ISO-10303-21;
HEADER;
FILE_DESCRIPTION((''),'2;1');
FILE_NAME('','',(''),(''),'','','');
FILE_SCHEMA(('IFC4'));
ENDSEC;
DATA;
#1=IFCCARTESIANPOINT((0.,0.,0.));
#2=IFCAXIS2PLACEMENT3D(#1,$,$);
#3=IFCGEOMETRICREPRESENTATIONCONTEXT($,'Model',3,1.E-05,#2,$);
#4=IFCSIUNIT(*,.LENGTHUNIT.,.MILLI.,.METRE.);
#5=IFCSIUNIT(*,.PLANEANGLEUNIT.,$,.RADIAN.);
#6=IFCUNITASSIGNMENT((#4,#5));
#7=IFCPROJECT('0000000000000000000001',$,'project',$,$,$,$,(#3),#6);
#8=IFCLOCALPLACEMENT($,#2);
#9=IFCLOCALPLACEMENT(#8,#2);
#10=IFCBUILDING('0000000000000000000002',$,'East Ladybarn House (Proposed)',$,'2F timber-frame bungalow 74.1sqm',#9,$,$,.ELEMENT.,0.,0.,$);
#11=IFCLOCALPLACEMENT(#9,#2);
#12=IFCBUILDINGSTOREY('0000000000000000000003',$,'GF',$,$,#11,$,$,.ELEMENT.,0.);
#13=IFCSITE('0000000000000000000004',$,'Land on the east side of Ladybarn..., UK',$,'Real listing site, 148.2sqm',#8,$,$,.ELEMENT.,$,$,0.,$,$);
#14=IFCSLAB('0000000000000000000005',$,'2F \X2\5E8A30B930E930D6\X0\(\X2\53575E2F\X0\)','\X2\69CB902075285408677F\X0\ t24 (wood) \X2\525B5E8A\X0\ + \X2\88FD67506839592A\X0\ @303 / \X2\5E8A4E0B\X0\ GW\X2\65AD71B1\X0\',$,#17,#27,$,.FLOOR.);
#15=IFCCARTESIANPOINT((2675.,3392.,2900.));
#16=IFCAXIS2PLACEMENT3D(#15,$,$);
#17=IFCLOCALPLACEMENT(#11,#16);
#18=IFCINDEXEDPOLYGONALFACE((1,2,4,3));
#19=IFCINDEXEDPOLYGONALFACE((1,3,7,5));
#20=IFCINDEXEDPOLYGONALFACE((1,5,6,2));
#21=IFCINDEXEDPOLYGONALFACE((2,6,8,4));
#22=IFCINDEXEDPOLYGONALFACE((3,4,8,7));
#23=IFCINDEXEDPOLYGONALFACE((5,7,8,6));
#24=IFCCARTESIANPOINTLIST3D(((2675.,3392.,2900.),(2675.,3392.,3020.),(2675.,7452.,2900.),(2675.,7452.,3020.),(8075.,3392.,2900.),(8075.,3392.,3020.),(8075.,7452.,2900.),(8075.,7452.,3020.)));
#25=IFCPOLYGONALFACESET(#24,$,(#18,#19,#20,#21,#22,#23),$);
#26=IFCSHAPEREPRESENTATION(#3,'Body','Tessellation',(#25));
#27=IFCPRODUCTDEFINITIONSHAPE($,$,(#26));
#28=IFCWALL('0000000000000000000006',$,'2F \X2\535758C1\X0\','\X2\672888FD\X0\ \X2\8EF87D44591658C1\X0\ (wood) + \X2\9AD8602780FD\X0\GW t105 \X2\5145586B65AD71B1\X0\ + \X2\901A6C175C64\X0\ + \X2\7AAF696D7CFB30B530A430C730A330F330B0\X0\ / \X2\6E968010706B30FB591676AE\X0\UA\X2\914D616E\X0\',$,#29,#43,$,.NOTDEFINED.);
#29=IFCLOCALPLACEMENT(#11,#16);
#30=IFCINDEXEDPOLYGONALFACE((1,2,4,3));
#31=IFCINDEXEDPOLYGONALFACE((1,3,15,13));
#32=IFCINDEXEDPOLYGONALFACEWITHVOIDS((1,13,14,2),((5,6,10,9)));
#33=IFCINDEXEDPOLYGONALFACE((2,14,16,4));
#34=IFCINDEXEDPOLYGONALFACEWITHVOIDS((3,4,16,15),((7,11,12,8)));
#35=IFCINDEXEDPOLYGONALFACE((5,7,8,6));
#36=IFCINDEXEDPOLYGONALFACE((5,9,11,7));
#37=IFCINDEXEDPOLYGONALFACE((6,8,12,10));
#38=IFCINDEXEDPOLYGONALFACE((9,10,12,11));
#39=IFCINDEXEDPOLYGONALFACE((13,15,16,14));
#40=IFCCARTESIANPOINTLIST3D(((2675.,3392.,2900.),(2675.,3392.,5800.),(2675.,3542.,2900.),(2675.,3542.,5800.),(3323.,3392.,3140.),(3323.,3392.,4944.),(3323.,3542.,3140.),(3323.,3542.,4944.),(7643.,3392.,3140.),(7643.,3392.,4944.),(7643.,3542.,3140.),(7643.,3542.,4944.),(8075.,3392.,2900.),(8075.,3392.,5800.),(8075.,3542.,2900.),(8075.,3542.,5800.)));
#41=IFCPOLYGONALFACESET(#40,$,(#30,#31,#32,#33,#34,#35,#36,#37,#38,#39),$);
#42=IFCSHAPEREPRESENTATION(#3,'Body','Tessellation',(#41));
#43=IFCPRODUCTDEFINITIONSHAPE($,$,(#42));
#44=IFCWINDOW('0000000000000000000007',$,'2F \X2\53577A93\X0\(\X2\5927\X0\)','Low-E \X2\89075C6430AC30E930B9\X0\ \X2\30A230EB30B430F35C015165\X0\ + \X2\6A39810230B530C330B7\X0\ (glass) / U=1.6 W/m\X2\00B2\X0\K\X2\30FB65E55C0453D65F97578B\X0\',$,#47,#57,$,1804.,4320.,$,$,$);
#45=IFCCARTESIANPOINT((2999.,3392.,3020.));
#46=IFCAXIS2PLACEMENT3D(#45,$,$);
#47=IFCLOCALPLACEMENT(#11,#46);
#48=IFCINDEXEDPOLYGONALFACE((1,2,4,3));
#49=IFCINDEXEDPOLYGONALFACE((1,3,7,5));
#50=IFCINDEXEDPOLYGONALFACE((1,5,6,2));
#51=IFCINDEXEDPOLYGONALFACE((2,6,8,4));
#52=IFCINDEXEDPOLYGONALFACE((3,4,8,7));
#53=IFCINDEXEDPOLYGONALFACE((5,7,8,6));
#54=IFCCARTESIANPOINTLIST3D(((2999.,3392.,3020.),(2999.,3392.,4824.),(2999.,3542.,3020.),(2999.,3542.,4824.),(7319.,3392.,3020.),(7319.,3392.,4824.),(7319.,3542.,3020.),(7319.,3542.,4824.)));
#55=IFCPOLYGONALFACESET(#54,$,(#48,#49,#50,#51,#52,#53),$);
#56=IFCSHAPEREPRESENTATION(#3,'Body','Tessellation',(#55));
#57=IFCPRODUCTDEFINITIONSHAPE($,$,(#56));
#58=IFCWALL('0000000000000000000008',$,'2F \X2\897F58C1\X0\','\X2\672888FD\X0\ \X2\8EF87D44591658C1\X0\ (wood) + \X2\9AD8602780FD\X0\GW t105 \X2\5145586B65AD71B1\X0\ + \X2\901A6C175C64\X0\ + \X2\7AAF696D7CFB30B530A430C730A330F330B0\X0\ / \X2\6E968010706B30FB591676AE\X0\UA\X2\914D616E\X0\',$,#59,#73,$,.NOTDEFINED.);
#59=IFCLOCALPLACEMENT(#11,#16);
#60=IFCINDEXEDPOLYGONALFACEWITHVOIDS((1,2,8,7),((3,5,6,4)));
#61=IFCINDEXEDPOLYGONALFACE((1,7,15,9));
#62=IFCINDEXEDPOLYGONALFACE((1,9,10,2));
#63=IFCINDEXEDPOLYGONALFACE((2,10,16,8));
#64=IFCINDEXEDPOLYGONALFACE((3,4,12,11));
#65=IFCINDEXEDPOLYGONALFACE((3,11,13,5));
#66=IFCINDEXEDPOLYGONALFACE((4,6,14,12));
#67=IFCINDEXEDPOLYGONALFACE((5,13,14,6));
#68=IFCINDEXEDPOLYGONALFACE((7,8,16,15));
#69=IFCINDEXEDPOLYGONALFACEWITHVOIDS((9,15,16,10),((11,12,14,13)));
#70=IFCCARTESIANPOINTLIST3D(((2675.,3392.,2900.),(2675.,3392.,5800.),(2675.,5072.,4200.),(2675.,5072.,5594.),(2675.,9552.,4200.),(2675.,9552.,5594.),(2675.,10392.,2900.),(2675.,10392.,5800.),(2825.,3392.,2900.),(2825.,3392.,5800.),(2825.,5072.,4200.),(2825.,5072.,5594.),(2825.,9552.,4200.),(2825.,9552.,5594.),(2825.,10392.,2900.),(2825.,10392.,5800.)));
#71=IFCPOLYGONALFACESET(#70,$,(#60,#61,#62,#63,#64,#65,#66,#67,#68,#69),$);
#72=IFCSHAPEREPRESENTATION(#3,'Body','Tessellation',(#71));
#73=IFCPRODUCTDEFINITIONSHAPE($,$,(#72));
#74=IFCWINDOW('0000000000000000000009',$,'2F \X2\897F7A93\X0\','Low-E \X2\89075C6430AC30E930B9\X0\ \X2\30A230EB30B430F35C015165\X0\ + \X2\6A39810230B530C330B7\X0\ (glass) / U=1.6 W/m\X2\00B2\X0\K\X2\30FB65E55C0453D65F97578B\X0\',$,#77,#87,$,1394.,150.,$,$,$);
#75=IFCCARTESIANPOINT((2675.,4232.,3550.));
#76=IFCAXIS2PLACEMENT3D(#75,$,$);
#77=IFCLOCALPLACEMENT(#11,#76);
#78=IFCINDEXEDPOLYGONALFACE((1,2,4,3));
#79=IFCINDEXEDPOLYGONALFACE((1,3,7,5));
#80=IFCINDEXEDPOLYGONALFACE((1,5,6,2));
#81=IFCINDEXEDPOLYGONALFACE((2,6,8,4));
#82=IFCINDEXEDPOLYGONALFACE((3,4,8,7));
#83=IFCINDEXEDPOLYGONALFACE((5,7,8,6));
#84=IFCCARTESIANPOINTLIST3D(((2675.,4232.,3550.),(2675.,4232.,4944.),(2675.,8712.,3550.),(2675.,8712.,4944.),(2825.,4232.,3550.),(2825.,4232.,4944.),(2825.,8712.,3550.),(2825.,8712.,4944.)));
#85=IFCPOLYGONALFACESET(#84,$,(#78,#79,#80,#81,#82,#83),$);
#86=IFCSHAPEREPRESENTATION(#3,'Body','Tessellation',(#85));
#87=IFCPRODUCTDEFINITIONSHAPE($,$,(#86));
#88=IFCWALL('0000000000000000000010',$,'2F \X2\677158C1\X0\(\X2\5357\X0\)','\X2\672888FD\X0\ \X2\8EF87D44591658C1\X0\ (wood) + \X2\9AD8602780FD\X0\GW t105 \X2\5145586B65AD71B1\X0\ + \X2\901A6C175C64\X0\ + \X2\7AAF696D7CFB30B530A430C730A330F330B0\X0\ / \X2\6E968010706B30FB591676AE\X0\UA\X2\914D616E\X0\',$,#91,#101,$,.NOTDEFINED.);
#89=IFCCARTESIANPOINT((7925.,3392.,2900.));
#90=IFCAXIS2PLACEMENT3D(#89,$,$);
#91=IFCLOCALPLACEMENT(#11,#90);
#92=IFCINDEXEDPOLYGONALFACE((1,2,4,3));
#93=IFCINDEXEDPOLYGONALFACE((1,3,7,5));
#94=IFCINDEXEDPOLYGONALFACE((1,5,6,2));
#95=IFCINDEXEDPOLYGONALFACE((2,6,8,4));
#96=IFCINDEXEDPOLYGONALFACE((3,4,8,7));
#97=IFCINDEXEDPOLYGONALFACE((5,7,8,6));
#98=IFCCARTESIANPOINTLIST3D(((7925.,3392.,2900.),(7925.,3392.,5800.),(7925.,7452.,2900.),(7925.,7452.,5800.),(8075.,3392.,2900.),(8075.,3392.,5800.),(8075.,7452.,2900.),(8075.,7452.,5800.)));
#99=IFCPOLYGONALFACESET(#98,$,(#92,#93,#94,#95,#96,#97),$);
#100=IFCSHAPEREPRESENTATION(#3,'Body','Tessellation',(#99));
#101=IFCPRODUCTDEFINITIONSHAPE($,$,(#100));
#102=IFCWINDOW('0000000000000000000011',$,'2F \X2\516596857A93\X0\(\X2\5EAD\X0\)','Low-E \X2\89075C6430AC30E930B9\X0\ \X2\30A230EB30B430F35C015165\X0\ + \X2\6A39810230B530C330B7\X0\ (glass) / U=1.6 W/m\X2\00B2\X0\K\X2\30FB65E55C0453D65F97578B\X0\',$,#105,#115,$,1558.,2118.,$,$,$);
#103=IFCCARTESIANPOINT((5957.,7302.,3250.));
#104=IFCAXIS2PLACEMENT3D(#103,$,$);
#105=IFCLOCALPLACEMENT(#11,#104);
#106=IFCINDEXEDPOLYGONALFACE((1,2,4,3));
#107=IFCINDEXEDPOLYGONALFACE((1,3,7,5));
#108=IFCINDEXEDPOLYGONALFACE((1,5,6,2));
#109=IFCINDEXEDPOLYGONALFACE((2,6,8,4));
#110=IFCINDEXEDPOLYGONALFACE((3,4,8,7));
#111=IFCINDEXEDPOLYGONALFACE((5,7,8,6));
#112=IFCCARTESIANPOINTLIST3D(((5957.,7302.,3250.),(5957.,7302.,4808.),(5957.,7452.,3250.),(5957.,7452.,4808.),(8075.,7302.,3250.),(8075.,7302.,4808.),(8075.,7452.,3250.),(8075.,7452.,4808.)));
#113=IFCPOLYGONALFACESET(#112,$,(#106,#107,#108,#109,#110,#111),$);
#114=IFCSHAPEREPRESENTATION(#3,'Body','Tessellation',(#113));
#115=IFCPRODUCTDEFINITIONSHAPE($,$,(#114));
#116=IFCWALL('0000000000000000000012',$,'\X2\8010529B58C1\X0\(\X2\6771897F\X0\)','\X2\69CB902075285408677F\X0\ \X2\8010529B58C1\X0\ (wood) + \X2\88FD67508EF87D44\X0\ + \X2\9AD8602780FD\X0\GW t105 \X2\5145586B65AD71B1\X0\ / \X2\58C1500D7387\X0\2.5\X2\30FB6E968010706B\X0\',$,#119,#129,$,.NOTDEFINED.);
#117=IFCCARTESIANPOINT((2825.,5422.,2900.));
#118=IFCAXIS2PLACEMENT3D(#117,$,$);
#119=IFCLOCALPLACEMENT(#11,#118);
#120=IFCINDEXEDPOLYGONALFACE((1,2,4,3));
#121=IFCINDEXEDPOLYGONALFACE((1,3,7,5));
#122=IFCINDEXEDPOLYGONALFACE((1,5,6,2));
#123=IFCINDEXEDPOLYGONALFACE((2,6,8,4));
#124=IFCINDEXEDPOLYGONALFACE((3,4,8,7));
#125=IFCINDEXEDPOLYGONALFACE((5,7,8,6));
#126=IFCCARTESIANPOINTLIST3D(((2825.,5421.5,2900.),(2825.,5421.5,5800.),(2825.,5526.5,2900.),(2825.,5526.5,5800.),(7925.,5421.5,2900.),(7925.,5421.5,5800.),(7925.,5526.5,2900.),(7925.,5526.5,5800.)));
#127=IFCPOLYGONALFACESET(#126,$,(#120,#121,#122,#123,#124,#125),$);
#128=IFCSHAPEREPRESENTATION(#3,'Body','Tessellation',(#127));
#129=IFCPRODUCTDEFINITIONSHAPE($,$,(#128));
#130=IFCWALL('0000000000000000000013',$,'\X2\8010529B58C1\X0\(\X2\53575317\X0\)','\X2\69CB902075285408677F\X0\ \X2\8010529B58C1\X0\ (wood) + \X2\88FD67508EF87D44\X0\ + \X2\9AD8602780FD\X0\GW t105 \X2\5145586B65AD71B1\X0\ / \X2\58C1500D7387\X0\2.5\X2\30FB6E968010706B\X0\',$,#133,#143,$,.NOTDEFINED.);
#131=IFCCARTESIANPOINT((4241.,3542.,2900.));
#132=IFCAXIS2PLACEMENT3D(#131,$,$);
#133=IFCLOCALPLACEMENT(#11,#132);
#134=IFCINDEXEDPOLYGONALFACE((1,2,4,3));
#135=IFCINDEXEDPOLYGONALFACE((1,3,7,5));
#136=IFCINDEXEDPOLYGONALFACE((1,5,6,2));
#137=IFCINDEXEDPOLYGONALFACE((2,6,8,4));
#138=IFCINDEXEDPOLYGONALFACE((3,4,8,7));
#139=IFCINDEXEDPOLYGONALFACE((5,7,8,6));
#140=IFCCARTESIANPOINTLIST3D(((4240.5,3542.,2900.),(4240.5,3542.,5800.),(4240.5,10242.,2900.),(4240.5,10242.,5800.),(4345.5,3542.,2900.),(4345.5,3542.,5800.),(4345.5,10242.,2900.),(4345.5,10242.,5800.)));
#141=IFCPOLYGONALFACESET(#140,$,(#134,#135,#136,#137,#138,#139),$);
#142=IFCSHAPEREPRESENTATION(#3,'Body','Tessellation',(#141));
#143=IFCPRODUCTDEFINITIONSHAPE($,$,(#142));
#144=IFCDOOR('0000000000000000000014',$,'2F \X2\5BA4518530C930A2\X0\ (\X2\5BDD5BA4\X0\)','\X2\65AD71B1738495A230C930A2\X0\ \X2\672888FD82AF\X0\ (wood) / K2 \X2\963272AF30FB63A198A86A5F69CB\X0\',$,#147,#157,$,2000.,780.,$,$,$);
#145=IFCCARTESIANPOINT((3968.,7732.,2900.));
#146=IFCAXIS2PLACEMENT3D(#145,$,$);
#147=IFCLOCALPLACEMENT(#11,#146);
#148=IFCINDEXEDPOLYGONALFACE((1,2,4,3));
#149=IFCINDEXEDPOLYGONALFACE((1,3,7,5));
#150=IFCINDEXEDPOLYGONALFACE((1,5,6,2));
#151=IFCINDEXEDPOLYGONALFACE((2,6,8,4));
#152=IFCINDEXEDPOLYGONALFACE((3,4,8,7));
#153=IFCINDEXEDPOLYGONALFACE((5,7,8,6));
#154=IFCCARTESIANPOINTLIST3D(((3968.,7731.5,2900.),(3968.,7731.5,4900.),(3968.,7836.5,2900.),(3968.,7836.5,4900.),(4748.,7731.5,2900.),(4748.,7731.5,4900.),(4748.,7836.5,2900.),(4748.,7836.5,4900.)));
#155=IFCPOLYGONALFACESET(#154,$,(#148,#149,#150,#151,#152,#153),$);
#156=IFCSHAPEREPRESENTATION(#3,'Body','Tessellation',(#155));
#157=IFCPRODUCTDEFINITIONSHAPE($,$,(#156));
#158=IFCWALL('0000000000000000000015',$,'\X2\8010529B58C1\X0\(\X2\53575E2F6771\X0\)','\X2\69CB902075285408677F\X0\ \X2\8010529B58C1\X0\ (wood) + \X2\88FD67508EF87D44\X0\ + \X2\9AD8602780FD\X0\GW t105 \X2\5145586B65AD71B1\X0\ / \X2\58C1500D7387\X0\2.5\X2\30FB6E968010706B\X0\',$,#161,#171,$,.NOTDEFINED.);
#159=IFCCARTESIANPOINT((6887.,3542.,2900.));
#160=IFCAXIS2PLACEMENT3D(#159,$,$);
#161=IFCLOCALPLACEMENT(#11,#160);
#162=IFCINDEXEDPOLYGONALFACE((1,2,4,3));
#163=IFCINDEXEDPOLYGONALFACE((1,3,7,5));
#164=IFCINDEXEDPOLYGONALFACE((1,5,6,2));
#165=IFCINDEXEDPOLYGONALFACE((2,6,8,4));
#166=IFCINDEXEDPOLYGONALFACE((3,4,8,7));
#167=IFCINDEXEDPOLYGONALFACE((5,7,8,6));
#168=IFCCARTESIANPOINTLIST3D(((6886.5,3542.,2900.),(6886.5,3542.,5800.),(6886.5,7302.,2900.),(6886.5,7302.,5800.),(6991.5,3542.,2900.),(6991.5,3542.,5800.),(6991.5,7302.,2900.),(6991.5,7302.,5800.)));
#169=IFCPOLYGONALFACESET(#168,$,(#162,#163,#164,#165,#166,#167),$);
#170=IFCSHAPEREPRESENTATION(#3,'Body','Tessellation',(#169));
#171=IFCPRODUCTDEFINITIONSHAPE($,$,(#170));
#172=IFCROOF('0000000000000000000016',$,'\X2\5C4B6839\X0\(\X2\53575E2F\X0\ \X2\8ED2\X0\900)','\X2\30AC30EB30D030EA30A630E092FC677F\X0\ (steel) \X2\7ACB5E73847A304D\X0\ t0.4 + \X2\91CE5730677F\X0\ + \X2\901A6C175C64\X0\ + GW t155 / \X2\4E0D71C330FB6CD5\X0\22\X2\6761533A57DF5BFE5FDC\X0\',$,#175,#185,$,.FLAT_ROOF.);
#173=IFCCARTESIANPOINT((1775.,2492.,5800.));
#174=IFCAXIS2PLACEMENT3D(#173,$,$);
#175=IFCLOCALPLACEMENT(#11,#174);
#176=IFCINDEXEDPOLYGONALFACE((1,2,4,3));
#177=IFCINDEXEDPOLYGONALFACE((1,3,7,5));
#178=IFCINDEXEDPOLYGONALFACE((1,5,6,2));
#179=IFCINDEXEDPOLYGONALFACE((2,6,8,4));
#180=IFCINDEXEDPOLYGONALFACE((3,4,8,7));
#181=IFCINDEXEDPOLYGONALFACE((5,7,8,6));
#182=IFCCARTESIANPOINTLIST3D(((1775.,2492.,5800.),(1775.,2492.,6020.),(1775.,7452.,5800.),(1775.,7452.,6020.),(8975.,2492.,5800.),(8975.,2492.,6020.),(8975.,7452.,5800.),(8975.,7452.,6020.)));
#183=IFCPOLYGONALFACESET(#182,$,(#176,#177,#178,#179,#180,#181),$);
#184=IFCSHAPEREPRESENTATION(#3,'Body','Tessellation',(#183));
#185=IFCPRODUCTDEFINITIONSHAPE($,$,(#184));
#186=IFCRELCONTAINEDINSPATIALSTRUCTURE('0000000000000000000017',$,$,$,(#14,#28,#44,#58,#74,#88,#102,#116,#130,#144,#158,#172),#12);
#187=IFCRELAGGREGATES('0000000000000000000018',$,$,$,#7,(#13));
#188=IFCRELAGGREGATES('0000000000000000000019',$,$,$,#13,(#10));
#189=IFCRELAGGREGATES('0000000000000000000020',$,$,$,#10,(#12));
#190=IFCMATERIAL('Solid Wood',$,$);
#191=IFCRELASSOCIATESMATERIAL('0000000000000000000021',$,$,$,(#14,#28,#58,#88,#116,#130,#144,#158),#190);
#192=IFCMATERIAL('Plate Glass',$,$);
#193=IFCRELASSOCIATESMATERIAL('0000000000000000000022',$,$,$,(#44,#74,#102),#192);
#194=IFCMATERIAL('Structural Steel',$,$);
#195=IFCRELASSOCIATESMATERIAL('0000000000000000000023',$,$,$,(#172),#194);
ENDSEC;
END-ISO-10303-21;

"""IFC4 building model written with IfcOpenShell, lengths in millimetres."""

from ifc_helpers import new_model, si_unit, frame, frame_2d, origin, place, context, project, spatial, rectangle, extrude, material, element, fill, save


model = new_model("IFC4")

# Units and contexts
model_context = context("Model", 3, precision=1e-05, world=origin())
ifc_project = project(units=[si_unit("LENGTHUNIT", "METRE", prefix="MILLI"), si_unit("PLANEANGLEUNIT", "RADIAN")], contexts=[model_context])

# Site, building, storey
site_placement = place(None, origin())
site = spatial("IfcSite", under=ifc_project, at=site_placement, Name="Land on the east side of Ladybarn..., UK", ObjectType="Real listing site, 148.2sqm", CompositionType="ELEMENT", RefElevation=0.0)
building_placement = place(site_placement, origin())
building = spatial("IfcBuilding", under=site, at=building_placement, Name="East Ladybarn House (Proposed)", ObjectType="2F timber-frame bungalow 74.1sqm", CompositionType="ELEMENT", ElevationOfRefHeight=0.0, ElevationOfTerrain=0.0)
storey_placement = place(building_placement, origin())
storey = spatial("IfcBuildingStorey", under=building, at=storey_placement, Name="GF", CompositionType="ELEMENT", Elevation=0.0)

# Slab
ifc_material_1 = material(Name="Solid Wood")
slab_placement = place(storey_placement, frame((2675.0, 3392.0, 2900.0)))
element("IfcSlab", 1, at=slab_placement, inside=storey, material=ifc_material_1, Name="2F 床スラブ(南帯)", Description="構造用合板 t24 (wood) 剛床 + 製材根太 @303 / 床下 GW断熱", PredefinedType="FLOOR", context=model_context, shape_type="SweptSolid", body=[
    extrude(rectangle(XDim=5400.0, YDim=4060.0, at=frame_2d((2700.0, 2030.0))), frame((2675.0, 3392.0, 2900.0)), (0.0, 0.0, 1.0), 120.0),
])

# Walls, openings, windows
wall_1_placement = place(storey_placement, frame((2675.0, 3392.0, 2900.0)))
wall_1 = element("IfcWall", 2, at=wall_1_placement, inside=storey, material=ifc_material_1, Name="2F 南壁", Description="木製 軸組外壁 (wood) + 高性能GW t105 充填断熱 + 通気層 + 窯業系サイディング / 準耐火・外皮UA配慮", PredefinedType="NOTDEFINED", context=model_context, shape_type="SweptSolid", body=[
    extrude(rectangle(XDim=5400.0, YDim=150.0, at=frame_2d((2700.0, 75.0))), frame((2675.0, 3392.0, 2900.0)), (0.0, 0.0, 1.0), 2900.0),
])
opening_1_placement = place(storey_placement, frame((2999.0, 3392.0, 3020.0)))
opening_1 = element("IfcOpeningElement", 3, at=opening_1_placement, cuts=wall_1, PredefinedType="NOTDEFINED", context=model_context, shape_type="SweptSolid", body=[
    extrude(rectangle(XDim=4320.0, YDim=150.0, at=frame_2d((2160.0, 75.0))), frame((2999.0, 3392.0, 3020.0)), (0.0, 0.0, 1.0), 1804.0),
])
ifc_material_2 = material(Name="Plate Glass")
window_1_placement = place(storey_placement, frame((2999.0, 3392.0, 3020.0)))
window_1 = element("IfcWindow", 4, at=window_1_placement, inside=storey, material=ifc_material_2, Name="2F 南窓(大)", Description="Low-E 複層ガラス アルゴン封入 + 樹脂サッシ (glass) / U=1.6 W/m²K・日射取得型", OverallHeight=1804.0, OverallWidth=4320.0, context=model_context, shape_type="SweptSolid", body=[
    extrude(rectangle(XDim=4320.0, YDim=150.0, at=frame_2d((2160.0, 75.0))), frame((2999.0, 3392.0, 3020.0)), (0.0, 0.0, 1.0), 1804.0),
])
fill(opening_1, window_1)
wall_2_placement = place(storey_placement, frame((2675.0, 3392.0, 2900.0)))
wall_2 = element("IfcWall", 5, at=wall_2_placement, inside=storey, material=ifc_material_1, Name="2F 西壁", Description="木製 軸組外壁 (wood) + 高性能GW t105 充填断熱 + 通気層 + 窯業系サイディング / 準耐火・外皮UA配慮", PredefinedType="NOTDEFINED", context=model_context, shape_type="SweptSolid", body=[
    extrude(rectangle(XDim=150.0, YDim=7000.0, at=frame_2d((75.0, 3500.0))), frame((2675.0, 3392.0, 2900.0)), (0.0, 0.0, 1.0), 2900.0),
])
opening_2_placement = place(storey_placement, frame((2675.0, 4232.0, 3550.0)))
opening_2 = element("IfcOpeningElement", 6, at=opening_2_placement, cuts=wall_2, PredefinedType="NOTDEFINED", context=model_context, shape_type="SweptSolid", body=[
    extrude(rectangle(XDim=150.0, YDim=4480.0, at=frame_2d((75.0, 2240.0))), frame((2675.0, 4232.0, 3550.0)), (0.0, 0.0, 1.0), 1394.0),
])
window_2_placement = place(storey_placement, frame((2675.0, 4232.0, 3550.0)))
window_2 = element("IfcWindow", 7, at=window_2_placement, inside=storey, material=ifc_material_2, Name="2F 西窓", Description="Low-E 複層ガラス アルゴン封入 + 樹脂サッシ (glass) / U=1.6 W/m²K・日射取得型", OverallHeight=1394.0, OverallWidth=150.0, context=model_context, shape_type="SweptSolid", body=[
    extrude(rectangle(XDim=150.0, YDim=4480.0, at=frame_2d((75.0, 2240.0))), frame((2675.0, 4232.0, 3550.0)), (0.0, 0.0, 1.0), 1394.0),
])
fill(opening_2, window_2)
wall_3_placement = place(storey_placement, frame((7925.0, 3392.0, 2900.0)))
wall_3 = element("IfcWall", 8, at=wall_3_placement, inside=storey, material=ifc_material_1, Name="2F 東壁(南)", Description="木製 軸組外壁 (wood) + 高性能GW t105 充填断熱 + 通気層 + 窯業系サイディング / 準耐火・外皮UA配慮", PredefinedType="NOTDEFINED", context=model_context, shape_type="SweptSolid", body=[
    extrude(rectangle(XDim=150.0, YDim=4060.0, at=frame_2d((75.0, 2030.0))), frame((7925.0, 3392.0, 2900.0)), (0.0, 0.0, 1.0), 2900.0),
])
opening_3_placement = place(storey_placement, frame((5957.0, 7302.0, 3250.0)))
opening_3 = element("IfcOpeningElement", 9, at=opening_3_placement, cuts=wall_3, PredefinedType="NOTDEFINED", context=model_context, shape_type="SweptSolid", body=[
    extrude(rectangle(XDim=2118.0, YDim=150.0, at=frame_2d((1059.0, 75.0))), frame((5957.0, 7302.0, 3250.0)), (0.0, 0.0, 1.0), 1558.0),
])
window_3_placement = place(storey_placement, frame((5957.0, 7302.0, 3250.0)))
window_3 = element("IfcWindow", 10, at=window_3_placement, inside=storey, material=ifc_material_2, Name="2F 入隅窓(庭)", Description="Low-E 複層ガラス アルゴン封入 + 樹脂サッシ (glass) / U=1.6 W/m²K・日射取得型", OverallHeight=1558.0, OverallWidth=2118.0, context=model_context, shape_type="SweptSolid", body=[
    extrude(rectangle(XDim=2118.0, YDim=150.0, at=frame_2d((1059.0, 75.0))), frame((5957.0, 7302.0, 3250.0)), (0.0, 0.0, 1.0), 1558.0),
])
fill(opening_3, window_3)

# Wall
wall_4_placement = place(storey_placement, frame((2825.0, 5422.0, 2900.0)))
element("IfcWall", 11, at=wall_4_placement, inside=storey, material=ifc_material_1, Name="耐力壁(東西)", Description="構造用合板 耐力壁 (wood) + 製材軸組 + 高性能GW t105 充填断熱 / 壁倍率2.5・準耐火", PredefinedType="NOTDEFINED", context=model_context, shape_type="SweptSolid", body=[
    extrude(rectangle(XDim=5100.0, YDim=105.0, at=frame_2d((2550.0, 52.0))), frame((2825.0, 5422.0, 2900.0)), (0.0, 0.0, 1.0), 2900.0),
])

# Wall, opening, door
wall_5_placement = place(storey_placement, frame((4241.0, 3542.0, 2900.0)))
wall_5 = element("IfcWall", 12, at=wall_5_placement, inside=storey, material=ifc_material_1, Name="耐力壁(南北)", Description="構造用合板 耐力壁 (wood) + 製材軸組 + 高性能GW t105 充填断熱 / 壁倍率2.5・準耐火", PredefinedType="NOTDEFINED", context=model_context, shape_type="SweptSolid", body=[
    extrude(rectangle(XDim=105.0, YDim=6700.0, at=frame_2d((52.0, 3350.0))), frame((4241.0, 3542.0, 2900.0)), (0.0, 0.0, 1.0), 2900.0),
])
opening_4_placement = place(storey_placement, frame((3968.0, 7732.0, 2900.0)))
opening_4 = element("IfcOpeningElement", 13, at=opening_4_placement, cuts=wall_5, PredefinedType="NOTDEFINED", context=model_context, shape_type="SweptSolid", body=[
    extrude(rectangle(XDim=780.0, YDim=105.0, at=frame_2d((390.0, 52.0))), frame((3968.0, 7732.0, 2900.0)), (0.0, 0.0, 1.0), 2000.0),
])
door_placement = place(storey_placement, frame((3968.0, 7732.0, 2900.0)))
door = element("IfcDoor", 14, at=door_placement, inside=storey, material=ifc_material_1, Name="2F 室内ドア (寝室)", Description="断熱玄関ドア 木製芯 (wood) / K2 防犯・採風機構", OverallHeight=2000.0, OverallWidth=780.0, context=model_context, shape_type="SweptSolid", body=[
    extrude(rectangle(XDim=780.0, YDim=105.0, at=frame_2d((390.0, 52.0))), frame((3968.0, 7732.0, 2900.0)), (0.0, 0.0, 1.0), 2000.0),
])
fill(opening_4, door)

# Wall
wall_6_placement = place(storey_placement, frame((6887.0, 3542.0, 2900.0)))
element("IfcWall", 15, at=wall_6_placement, inside=storey, material=ifc_material_1, Name="耐力壁(南帯東)", Description="構造用合板 耐力壁 (wood) + 製材軸組 + 高性能GW t105 充填断熱 / 壁倍率2.5・準耐火", PredefinedType="NOTDEFINED", context=model_context, shape_type="SweptSolid", body=[
    extrude(rectangle(XDim=105.0, YDim=3760.0, at=frame_2d((52.0, 1880.0))), frame((6887.0, 3542.0, 2900.0)), (0.0, 0.0, 1.0), 2900.0),
])

# Roof
ifc_material_3 = material(Name="Structural Steel")
for number, where, name in (
    (16, (1775.0, 2492.0, 5800.0), "屋根(南帯 軒900)"),
):
    element("IfcRoof", number, at=place(storey_placement, frame(where)), inside=storey, material=ifc_material_3, Name=name, Description="ガルバリウム鋼板 (steel) 立平葺き t0.4 + 野地板 + 通気層 + GW t155 / 不燃・法22条区域対応", PredefinedType="FLAT_ROOF", context=model_context, shape_type="SweptSolid", body=[
        extrude(rectangle(XDim=7200.0, YDim=4960.0, at=frame_2d((3600.0, 2480.0))), frame((1775.0, 2492.0, 5800.0)), (0.0, 0.0, 1.0), 220.0),
    ])

save(model, "model.ifc")
